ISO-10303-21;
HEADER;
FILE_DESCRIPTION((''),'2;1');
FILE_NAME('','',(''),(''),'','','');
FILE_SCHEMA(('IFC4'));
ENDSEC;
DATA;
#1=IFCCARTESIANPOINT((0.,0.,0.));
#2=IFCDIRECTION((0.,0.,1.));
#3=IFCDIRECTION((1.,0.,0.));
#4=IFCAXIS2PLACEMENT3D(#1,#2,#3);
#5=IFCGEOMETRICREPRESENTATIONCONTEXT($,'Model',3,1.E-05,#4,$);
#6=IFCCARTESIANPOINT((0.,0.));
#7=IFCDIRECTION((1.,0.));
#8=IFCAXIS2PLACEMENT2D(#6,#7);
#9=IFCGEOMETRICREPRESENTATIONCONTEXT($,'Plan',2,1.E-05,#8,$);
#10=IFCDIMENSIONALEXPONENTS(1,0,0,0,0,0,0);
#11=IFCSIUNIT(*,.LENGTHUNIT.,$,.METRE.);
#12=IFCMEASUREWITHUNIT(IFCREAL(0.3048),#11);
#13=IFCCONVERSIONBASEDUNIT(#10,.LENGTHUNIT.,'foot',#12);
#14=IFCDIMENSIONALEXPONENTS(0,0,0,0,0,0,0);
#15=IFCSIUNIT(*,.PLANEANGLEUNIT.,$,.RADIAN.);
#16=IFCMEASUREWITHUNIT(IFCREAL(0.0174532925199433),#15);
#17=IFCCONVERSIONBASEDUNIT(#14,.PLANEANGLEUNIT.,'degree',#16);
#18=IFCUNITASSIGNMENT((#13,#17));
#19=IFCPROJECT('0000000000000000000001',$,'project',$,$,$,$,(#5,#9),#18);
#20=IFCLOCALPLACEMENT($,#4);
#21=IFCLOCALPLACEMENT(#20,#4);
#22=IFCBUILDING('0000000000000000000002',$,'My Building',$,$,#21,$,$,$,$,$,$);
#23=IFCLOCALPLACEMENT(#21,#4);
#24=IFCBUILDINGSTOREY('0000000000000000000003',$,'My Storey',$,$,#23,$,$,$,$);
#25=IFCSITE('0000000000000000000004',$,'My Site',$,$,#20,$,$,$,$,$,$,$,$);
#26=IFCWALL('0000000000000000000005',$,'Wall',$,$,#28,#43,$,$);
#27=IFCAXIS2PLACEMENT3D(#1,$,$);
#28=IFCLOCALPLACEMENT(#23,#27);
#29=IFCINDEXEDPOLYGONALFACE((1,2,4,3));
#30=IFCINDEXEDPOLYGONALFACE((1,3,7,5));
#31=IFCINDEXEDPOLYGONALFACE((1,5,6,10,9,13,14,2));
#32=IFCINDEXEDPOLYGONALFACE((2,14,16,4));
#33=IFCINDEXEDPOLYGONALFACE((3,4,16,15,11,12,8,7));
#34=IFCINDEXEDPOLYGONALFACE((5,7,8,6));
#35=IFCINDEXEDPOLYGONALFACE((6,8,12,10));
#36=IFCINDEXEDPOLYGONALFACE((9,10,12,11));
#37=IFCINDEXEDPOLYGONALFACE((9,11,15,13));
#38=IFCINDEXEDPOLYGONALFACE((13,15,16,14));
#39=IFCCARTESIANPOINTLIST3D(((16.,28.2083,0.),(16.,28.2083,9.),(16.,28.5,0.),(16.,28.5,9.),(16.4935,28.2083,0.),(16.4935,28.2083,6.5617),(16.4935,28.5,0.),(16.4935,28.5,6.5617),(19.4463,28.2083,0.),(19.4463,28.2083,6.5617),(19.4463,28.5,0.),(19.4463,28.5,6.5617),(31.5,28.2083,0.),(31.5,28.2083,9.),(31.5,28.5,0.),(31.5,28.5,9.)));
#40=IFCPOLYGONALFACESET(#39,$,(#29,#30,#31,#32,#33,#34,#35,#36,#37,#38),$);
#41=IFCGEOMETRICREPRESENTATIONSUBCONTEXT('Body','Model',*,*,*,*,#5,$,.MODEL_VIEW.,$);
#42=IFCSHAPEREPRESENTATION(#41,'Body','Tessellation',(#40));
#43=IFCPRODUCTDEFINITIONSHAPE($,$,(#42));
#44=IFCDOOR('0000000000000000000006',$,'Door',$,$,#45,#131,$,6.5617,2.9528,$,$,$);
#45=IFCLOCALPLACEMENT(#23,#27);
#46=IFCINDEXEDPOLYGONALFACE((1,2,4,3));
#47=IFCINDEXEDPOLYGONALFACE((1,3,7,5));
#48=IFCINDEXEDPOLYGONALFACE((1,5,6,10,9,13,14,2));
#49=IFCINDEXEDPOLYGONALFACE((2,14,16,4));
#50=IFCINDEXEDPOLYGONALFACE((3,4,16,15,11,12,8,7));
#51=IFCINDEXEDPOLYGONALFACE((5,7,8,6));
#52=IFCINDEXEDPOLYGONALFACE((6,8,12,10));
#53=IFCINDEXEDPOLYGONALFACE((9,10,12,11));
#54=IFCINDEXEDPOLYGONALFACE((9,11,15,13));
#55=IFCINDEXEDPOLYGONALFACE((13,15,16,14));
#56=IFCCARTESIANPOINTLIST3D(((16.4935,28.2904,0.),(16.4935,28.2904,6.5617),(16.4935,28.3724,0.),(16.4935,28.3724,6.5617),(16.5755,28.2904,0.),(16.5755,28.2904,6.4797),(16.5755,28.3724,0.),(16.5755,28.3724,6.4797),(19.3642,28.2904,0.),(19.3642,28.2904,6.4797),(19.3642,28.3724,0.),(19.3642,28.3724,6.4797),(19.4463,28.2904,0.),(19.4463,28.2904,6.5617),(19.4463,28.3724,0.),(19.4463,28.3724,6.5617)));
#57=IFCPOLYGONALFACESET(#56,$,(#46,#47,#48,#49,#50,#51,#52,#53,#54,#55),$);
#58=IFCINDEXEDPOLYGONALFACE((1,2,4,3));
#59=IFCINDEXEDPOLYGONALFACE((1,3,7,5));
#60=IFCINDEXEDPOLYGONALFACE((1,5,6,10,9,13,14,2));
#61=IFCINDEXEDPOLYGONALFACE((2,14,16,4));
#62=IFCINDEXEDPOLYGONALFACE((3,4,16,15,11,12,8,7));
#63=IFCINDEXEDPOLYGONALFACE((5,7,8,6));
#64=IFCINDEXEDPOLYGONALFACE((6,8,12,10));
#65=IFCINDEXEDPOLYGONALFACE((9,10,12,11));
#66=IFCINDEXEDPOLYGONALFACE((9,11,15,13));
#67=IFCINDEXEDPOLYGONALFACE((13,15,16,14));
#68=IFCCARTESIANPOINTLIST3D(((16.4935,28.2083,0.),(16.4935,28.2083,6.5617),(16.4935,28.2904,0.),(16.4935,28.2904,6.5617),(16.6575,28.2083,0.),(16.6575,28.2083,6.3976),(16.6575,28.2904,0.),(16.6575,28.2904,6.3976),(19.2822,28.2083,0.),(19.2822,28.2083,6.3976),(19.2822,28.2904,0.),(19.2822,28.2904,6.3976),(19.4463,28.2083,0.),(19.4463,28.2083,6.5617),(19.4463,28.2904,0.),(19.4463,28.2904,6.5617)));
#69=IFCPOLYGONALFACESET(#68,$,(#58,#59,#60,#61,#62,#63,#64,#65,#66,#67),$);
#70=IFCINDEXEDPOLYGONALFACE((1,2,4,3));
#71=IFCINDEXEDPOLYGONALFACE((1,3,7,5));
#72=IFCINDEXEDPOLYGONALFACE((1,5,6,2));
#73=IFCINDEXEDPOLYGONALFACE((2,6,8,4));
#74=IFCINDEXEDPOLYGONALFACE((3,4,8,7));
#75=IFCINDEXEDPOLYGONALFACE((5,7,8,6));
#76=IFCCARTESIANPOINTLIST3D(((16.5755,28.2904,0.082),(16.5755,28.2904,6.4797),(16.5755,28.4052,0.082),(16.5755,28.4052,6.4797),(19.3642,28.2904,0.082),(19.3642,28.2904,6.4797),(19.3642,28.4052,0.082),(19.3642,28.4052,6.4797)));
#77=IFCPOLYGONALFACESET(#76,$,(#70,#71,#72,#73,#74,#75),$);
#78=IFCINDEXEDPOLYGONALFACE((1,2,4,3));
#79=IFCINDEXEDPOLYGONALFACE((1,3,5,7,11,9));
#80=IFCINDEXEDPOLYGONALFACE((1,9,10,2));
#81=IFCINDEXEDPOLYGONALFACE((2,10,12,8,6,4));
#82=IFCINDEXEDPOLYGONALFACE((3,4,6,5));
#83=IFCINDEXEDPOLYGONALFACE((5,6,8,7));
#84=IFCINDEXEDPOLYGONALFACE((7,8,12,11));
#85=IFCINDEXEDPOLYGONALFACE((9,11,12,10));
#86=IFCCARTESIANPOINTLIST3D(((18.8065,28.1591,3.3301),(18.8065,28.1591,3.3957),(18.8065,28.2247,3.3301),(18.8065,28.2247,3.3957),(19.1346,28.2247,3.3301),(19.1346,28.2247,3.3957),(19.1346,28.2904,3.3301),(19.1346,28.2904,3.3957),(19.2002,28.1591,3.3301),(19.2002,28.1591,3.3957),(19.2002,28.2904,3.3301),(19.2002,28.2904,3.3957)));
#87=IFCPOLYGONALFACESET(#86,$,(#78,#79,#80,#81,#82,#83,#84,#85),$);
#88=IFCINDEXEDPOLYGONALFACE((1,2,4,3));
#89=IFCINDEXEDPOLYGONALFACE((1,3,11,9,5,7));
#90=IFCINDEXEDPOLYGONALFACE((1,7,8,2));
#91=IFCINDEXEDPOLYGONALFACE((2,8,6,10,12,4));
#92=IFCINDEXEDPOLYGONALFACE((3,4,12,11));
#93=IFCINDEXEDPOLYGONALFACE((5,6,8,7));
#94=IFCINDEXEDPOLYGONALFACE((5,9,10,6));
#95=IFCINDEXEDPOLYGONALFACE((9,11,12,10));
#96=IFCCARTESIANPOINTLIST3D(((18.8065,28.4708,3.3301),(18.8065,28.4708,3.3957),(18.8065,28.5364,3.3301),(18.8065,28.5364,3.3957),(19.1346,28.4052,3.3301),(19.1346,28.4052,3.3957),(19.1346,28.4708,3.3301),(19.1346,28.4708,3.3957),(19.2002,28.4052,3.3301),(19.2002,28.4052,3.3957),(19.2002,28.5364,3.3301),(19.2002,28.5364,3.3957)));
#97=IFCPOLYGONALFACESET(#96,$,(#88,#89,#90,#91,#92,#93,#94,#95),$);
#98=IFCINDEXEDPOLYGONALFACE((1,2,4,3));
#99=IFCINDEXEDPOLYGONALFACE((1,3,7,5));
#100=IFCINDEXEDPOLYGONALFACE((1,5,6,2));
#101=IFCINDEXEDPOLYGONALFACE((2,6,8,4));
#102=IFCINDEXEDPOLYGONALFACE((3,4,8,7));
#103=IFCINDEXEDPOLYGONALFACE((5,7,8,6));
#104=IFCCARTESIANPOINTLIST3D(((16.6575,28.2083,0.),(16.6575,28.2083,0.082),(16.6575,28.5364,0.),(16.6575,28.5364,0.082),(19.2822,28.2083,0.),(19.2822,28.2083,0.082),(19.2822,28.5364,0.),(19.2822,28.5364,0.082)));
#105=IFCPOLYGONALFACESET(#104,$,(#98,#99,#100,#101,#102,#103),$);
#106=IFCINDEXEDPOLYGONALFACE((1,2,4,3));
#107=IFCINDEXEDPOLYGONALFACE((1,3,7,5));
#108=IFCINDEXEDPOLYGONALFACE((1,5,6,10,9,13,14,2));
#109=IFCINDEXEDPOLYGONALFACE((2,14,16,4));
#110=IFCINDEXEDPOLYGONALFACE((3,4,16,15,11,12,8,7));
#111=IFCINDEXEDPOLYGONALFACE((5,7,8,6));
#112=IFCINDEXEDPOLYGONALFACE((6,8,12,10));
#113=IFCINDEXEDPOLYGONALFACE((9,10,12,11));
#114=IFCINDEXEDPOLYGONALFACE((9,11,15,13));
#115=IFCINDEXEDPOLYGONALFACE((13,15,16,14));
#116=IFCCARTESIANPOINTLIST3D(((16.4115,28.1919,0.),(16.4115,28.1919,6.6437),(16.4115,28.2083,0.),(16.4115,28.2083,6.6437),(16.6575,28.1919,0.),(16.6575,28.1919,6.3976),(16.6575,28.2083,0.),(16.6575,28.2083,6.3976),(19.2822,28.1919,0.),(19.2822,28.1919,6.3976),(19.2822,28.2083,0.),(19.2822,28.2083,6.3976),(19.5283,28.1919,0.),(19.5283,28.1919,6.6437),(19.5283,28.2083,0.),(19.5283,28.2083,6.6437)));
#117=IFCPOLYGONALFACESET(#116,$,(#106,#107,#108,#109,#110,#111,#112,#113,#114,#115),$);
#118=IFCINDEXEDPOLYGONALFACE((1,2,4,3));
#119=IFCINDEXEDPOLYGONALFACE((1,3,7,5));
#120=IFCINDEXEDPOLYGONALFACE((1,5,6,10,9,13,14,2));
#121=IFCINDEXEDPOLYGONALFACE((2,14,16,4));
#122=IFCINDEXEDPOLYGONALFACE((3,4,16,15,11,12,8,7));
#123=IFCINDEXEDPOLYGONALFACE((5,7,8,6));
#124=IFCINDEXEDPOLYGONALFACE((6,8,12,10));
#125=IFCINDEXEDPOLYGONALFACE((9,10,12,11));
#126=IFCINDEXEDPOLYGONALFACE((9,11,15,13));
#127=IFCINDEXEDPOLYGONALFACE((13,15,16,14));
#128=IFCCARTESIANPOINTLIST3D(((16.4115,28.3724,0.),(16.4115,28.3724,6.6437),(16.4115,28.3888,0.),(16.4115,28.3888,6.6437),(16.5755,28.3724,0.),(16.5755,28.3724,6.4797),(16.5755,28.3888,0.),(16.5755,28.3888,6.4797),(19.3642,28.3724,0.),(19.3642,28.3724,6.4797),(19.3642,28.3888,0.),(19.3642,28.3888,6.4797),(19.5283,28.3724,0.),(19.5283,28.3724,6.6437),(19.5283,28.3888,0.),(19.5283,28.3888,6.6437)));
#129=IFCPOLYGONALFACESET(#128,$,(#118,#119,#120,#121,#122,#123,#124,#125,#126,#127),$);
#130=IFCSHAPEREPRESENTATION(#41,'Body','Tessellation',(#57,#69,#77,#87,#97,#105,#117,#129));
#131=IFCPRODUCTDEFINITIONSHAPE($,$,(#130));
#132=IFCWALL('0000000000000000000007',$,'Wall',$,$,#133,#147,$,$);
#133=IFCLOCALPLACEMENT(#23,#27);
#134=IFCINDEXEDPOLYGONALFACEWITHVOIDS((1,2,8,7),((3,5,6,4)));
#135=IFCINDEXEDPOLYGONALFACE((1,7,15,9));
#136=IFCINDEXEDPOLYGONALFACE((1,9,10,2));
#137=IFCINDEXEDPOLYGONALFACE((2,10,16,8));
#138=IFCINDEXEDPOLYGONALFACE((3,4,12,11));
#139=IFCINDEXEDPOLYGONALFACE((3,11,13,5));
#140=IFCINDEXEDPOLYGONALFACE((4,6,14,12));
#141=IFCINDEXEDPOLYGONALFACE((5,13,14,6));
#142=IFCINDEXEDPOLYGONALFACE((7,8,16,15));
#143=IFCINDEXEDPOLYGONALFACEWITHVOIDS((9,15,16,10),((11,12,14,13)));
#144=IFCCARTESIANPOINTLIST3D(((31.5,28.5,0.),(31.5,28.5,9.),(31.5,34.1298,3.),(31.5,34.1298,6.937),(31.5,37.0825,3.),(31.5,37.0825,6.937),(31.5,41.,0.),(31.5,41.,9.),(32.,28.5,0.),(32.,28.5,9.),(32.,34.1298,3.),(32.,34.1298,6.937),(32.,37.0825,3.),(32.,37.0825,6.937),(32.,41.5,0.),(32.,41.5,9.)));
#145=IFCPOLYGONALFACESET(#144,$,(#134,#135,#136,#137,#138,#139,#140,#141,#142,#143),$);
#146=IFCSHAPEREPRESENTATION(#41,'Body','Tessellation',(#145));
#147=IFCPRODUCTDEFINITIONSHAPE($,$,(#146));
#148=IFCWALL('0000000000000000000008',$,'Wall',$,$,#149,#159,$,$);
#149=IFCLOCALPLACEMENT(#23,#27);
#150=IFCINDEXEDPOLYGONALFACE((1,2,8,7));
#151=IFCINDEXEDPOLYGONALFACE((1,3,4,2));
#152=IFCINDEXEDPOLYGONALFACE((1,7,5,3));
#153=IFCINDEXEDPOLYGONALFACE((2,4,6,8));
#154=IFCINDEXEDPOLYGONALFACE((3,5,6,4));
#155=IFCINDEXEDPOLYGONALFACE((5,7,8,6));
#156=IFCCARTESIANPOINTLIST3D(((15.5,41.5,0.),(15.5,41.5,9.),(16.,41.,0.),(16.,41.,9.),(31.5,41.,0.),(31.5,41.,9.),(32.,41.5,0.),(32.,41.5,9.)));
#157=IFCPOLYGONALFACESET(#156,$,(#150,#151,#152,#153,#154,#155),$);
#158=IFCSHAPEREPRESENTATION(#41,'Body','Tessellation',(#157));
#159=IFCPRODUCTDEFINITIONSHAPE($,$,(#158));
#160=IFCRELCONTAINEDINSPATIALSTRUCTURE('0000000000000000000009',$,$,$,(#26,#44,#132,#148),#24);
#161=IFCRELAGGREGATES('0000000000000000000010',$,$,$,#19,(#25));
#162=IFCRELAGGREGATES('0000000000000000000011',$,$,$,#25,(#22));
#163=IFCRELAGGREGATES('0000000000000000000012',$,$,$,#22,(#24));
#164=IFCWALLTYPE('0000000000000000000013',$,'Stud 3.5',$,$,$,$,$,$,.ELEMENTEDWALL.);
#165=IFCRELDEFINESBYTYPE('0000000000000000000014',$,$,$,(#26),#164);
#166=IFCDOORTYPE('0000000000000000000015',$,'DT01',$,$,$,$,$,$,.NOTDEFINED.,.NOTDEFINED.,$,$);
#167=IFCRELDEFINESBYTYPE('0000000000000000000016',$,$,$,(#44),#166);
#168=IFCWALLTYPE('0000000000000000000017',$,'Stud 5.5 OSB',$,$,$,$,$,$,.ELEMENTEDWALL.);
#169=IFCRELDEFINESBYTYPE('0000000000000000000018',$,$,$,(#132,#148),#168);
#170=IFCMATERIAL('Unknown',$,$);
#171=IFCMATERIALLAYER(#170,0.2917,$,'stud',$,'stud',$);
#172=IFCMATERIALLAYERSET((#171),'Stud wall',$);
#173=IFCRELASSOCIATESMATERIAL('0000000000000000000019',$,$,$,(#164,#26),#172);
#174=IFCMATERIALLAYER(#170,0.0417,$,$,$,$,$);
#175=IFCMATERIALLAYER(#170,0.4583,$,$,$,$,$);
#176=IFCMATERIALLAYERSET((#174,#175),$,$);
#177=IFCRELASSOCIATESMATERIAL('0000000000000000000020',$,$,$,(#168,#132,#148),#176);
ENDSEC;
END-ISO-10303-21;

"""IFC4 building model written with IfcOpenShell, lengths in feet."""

from ifc_helpers import new_model, entity, si_unit, converted_unit, frame, origin_with_axes, origin_2d_with_axis, place, context, subcontext, project, spatial, line, indexed_curve, outline, extrude, clip, halfspace, shape, source, transform, mapped, material, layer, layer_set, layer_usage, type_object, type_shapes, element, fill, save


model = new_model("IFC4")

# Units and contexts
model_context = context("Model", 3, precision=1e-05, world=origin_with_axes())
plan_context = context("Plan", 2, precision=1e-05, world=origin_2d_with_axis())
body_context_1 = subcontext(model_context, "Body", "Model", "MODEL_VIEW")
body_context_2 = subcontext(plan_context, "Body", "Plan", "PLAN_VIEW")
ifc_project = project(units=[converted_unit("LENGTHUNIT", "foot", entity("IfcReal", 0.3048), si_unit("LENGTHUNIT", "METRE"), dimensions=[1, 0, 0, 0, 0, 0, 0]), converted_unit("PLANEANGLEUNIT", "degree", entity("IfcReal", 0.0174532925199433), si_unit("PLANEANGLEUNIT", "RADIAN"), dimensions=[0, 0, 0, 0, 0, 0, 0])], contexts=[model_context, plan_context])

# Site, building, storey
site_placement = place(None, origin_with_axes())
site = spatial("IfcSite", under=ifc_project, at=site_placement, Name="My Site")
building_placement = place(site_placement, origin_with_axes())
building = spatial("IfcBuilding", under=site, at=building_placement, Name="My Building")
storey_placement = place(building_placement, origin_with_axes())
storey = spatial("IfcBuildingStorey", under=building, at=storey_placement, Name="My Storey")

# Wall, opening, door
ifc_material = material(Name="Unknown")
ifc_layer_1 = layer(ifc_material, 0.2917, Name="stud", Category="stud")
ifc_layer_set_1 = layer_set([ifc_layer_1], Name="Stud wall")
ifc_layer_usage_1 = layer_usage(ifc_layer_set_1, "AXIS2", "POSITIVE", 0.0)
wall_type_1 = type_object("IfcWallType", Name="Stud 3.5", PredefinedType="ELEMENTEDWALL", material=ifc_layer_set_1)
wall_1_placement = place(storey_placement, frame((31.5, 28.5, 0.0), z_axis=(0.0, 0.0, 1.0), x_axis=(-1.0, 0.000001, 0.0)))
wall_1 = element("IfcWall", 1, at=wall_1_placement, inside=storey, type_object=wall_type_1, material=ifc_layer_usage_1, Name="Wall", context=body_context_1, shape_type="SweptSolid", body=[
    extrude(outline(indexed_curve([(0.0, 0.0), (0.0, 0.2917), (15.5, 0.2917), (15.5, 0.0), (0.0, 0.0)], self_intersect=False)), origin_with_axes(), (0.0, 0.0, 1.0), 9.0),
])
shared_shape_1 = source(origin_with_axes(), body_context_1, "Body", "SweptSolid", [
    extrude(outline(indexed_curve([(0.0, 0.0), (2.9528, 0.0), (2.9528, 6.5617), (0.0, 6.5617)], segments=[line(1, 2, 3, 4, 1)])), frame((0.0, -1.9685, 0.0), z_axis=(0.0, -1.0, 0.0), x_axis=(1.0, 0.0, 0.0)), (0.0, 0.0, -1.0), 3.937),
])
opening_1_placement = place(wall_1_placement, frame((15.0065, 0.2917, 0.0), z_axis=(0.0, 0.0, 1.0), x_axis=(-1.0, 0.0, 0.0)))
opening_1 = element("IfcOpeningElement", 2, at=opening_1_placement, cuts=wall_1, PredefinedType="OPENING", context=body_context_1, shape_type="MappedRepresentation", body=[
    mapped(shared_shape_1, transform((0.0, 0.0, 0.0), x_axis=(1.0, 0.0, 0.0), y_axis=(0.0, 1.0, 0.0), z_axis=(0.0, 0.0, 1.0), scale=1.0)),
])
door_type = type_object("IfcDoorType", Name="DT01", OperationType="NOTDEFINED", PredefinedType="NOTDEFINED")
shared_shape_2 = source(origin_with_axes(), body_context_1, "Body", "SweptSolid", [
    extrude(outline(indexed_curve([(0.0, 0.0), (0.0, 6.5617), (2.9528, 6.5617), (2.9528, 0.0), (2.8707, 0.0), (2.8707, 6.4797), (0.082, 6.4797), (0.082, 0.0)], segments=[line(1, 2, 3, 4, 5, 6, 7, 8, 1)])), frame((0.0, 0.082, 0.0), z_axis=(0.0, -1.0, 0.0), x_axis=(1.0, 0.0, 0.0)), (0.0, 0.0, -1.0), 0.082),
    extrude(outline(indexed_curve([(0.0, 0.0), (0.0, 6.5617), (2.9528, 6.5617), (2.9528, 0.0), (2.7887, 0.0), (2.7887, 6.3976), (0.164, 6.3976), (0.164, 0.0)], segments=[line(1, 2, 3, 4, 5, 6, 7, 8, 1)])), frame((0.0, 0.0, 0.0), z_axis=(0.0, -1.0, 0.0), x_axis=(1.0, 0.0, 0.0)), (0.0, 0.0, -1.0), 0.082),
    extrude(outline(indexed_curve([(0.0, 0.0), (2.7887, 0.0), (2.7887, 0.1148), (0.0, 0.1148)], segments=[line(1, 2, 3, 4, 1)])), frame((0.082, 0.082, 0.082), z_axis=(0.0, 0.0, 1.0), x_axis=(1.0, 0.0, 0.0)), (0.0, 0.0, 1.0), 6.3976),
    extrude(outline(indexed_curve([(0.0, 0.0), (0.0, -0.1312), (-0.3937, -0.1312), (-0.3937, -0.0656), (-0.0656, -0.0656), (-0.0656, 0.0)], segments=[line(1, 2, 3, 4, 5, 6, 1)])), frame((2.7067, 0.082, 3.3301), z_axis=(0.0, 0.0, 1.0), x_axis=(1.0, 0.0, 0.0)), (0.0, 0.0, 1.0), 0.0656),
    extrude(outline(indexed_curve([(0.0, 0.0), (0.0, 0.1312), (-0.3937, 0.1312), (-0.3937, 0.0656), (-0.0656, 0.0656), (-0.0656, 0.0)], segments=[line(1, 2, 3, 4, 5, 6, 1)])), frame((2.7067, 0.1969, 3.3301), z_axis=(0.0, 0.0, 1.0), x_axis=(1.0, 0.0, 0.0)), (0.0, 0.0, 1.0), 0.0656),
    extrude(outline(indexed_curve([(0.0, 0.0), (2.6247, 0.0), (2.6247, 0.3281), (0.0, 0.3281)], segments=[line(1, 2, 3, 4, 1)])), frame((0.164, 0.0, 0.0), z_axis=(0.0, 0.0, 1.0), x_axis=(1.0, 0.0, 0.0)), (0.0, 0.0, 1.0), 0.082),
    extrude(outline(indexed_curve([(0.0, 0.0), (0.0, 6.6437), (3.1168, 6.6437), (3.1168, 0.0), (2.8707, 0.0), (2.8707, 6.3976), (0.2461, 6.3976), (0.2461, 0.0)], segments=[line(1, 2, 3, 4, 5, 6, 7, 8, 1)])), frame((-0.082, -0.0164, 0.0), z_axis=(0.0, -1.0, 0.0), x_axis=(1.0, 0.0, 0.0)), (0.0, 0.0, -1.0), 0.0164),
    extrude(outline(indexed_curve([(0.0, 0.0), (0.0, 6.6437), (3.1168, 6.6437), (3.1168, 0.0), (2.9528, 0.0), (2.9528, 6.4797), (0.164, 6.4797), (0.164, 0.0)], segments=[line(1, 2, 3, 4, 5, 6, 7, 8, 1)])), frame((-0.082, 0.164, 0.0), z_axis=(0.0, -1.0, 0.0), x_axis=(1.0, 0.0, 0.0)), (0.0, 0.0, -1.0), 0.0164),
])
shared_shape_3 = source(origin_with_axes(), body_context_2, "Body", "Curve2D", [
    entity("IfcIndexedPolyCurve", entity("IfcCartesianPointList2D", [[0.0, 0.0], [0.0, 0.164], [0.082, 0.164], [0.082, 0.082], [0.164, 0.082], [0.164, 0.0]]), [entity("IfcLineIndex", [1, 2, 3, 4, 5, 6, 1])]),
    entity("IfcIndexedPolyCurve", entity("IfcCartesianPointList2D", [[2.9528, 0.0], [2.9528, 0.164], [2.8707, 0.164], [2.8707, 0.082], [2.7887, 0.082], [2.7887, 0.0]]), [entity("IfcLineIndex", [1, 2, 3, 4, 5, 6, 1])]),
    entity("IfcTrimmedCurve", entity("IfcEllipse", entity("IfcAxis2Placement2D", entity("IfcCartesianPoint", [0.1969, 0.164]), entity("IfcDirection", [1.0, 0.0])), 2.6739, 2.7887), [entity("IfcCartesianPoint", [2.8707, 0.164])], [entity("IfcCartesianPoint", [0.1969, 2.9528])], True, "CARTESIAN"),
    entity("IfcIndexedPolyCurve", entity("IfcCartesianPointList2D", [[0.082, 0.164], [0.1969, 0.164], [0.1969, 2.9528], [0.082, 2.9528]]), [entity("IfcLineIndex", [1, 2, 3, 4, 1])]),
])
type_shapes(door_type, [shared_shape_2, shared_shape_3])
door_1_placement = place(opening_1_placement, frame((0.0, 0.0, 0.0), z_axis=(0.0, 0.0, 1.0), x_axis=(1.0, 0.0, 0.0)))
door_1 = element("IfcDoor", 3, at=door_1_placement, inside=storey, type_object=door_type, Name="Door", OverallHeight=6.5617, OverallWidth=2.9528, shapes=[
    shape(body_context_1, "Body", "MappedRepresentation", [mapped(shared_shape_2, transform((0.0, 0.0, 0.0), x_axis=(1.0, 0.0, 0.0), y_axis=(0.0, 1.0, 0.0), z_axis=(0.0, 0.0, 1.0), scale=1.0))]),
    shape(body_context_2, "Body", "MappedRepresentation", [mapped(shared_shape_3, transform((0.0, 0.0, 0.0), x_axis=(1.0, 0.0, 0.0), y_axis=(0.0, 1.0, 0.0), z_axis=(0.0, 0.0, 1.0), scale=1.0))]),
])
fill(opening_1, door_1)

# Wall, opening
ifc_layer_2 = layer(ifc_material, 0.0417)
ifc_layer_3 = layer(ifc_material, 0.4583)
ifc_layer_set_2 = layer_set([ifc_layer_2, ifc_layer_3])
ifc_layer_usage_2 = layer_usage(ifc_layer_set_2, "AXIS2", "POSITIVE", 0.0)
wall_type_2 = type_object("IfcWallType", Name="Stud 5.5 OSB", PredefinedType="ELEMENTEDWALL", material=ifc_layer_set_2)
wall_2_placement = place(storey_placement, frame((32.0, 28.5, 0.0), z_axis=(0.0, 0.0, 1.0), x_axis=(0.0, 1.0, 0.0)))
wall_2 = element("IfcWall", 4, at=wall_2_placement, inside=storey, type_object=wall_type_2, material=ifc_layer_usage_2, Name="Wall", context=body_context_1, shape_type="Clipping", body=[
    clip(extrude(outline(indexed_curve([(0.0, 0.0), (0.0, 0.5), (13.0, 0.5), (13.0, 0.0), (0.0, 0.0)], self_intersect=False)), origin_with_axes(), (0.0, 0.0, 1.0), 9.0), halfspace(frame((13.0, 0.0, 0.0), z_axis=(0.707106, 0.707107, 0.0), x_axis=(0.707107, -0.707107, 0.0)), False)),
])
shared_shape_4 = source(origin_with_axes(), body_context_1, "Body", "SweptSolid", [
    extrude(outline(indexed_curve([(0.0, 0.0), (2.9528, 0.0), (2.9528, 3.937), (0.0, 3.937)], segments=[line(1, 2, 3, 4, 1)])), frame((0.0, -1.9685, 0.0), z_axis=(0.0, -1.0, 0.0), x_axis=(1.0, 0.0, 0.0)), (0.0, 0.0, -1.0), 3.937),
])
opening_2_placement = place(wall_2_placement, frame((5.6298, 0.0, 3.0), z_axis=(0.0, 0.0, 1.0), x_axis=(1.0, 0.0, 0.0)))
element("IfcOpeningElement", 5, at=opening_2_placement, cuts=wall_2, PredefinedType="OPENING", context=body_context_1, shape_type="MappedRepresentation", body=[
    mapped(shared_shape_4, transform((0.0, 0.0, 0.0), x_axis=(1.0, 0.0, 0.0), y_axis=(0.0, 1.0, 0.0), z_axis=(0.0, 0.0, 1.0), scale=1.0)),
])

# Wall
ifc_layer_usage_3 = layer_usage(ifc_layer_set_2, "AXIS2", "POSITIVE", 0.0)
wall_3_placement = place(storey_placement, frame((32.0, 41.5, 0.0), z_axis=(0.0, 0.0, 1.0), x_axis=(-1.0, 0.0, 0.0)))
element("IfcWall", 6, at=wall_3_placement, inside=storey, type_object=wall_type_2, material=ifc_layer_usage_3, Name="Wall", context=body_context_1, shape_type="Clipping", body=[
    clip(clip(extrude(outline(indexed_curve([(0.0, 0.0), (0.0, 0.5), (16.5, 0.5), (16.5, 0.0), (0.0, 0.0)], self_intersect=False)), origin_with_axes(), (0.0, 0.0, 1.0), 9.0), halfspace(frame((0.0, 0.0, 0.0), z_axis=(-0.707107, 0.707106, 0.0), x_axis=(0.707106, 0.707107, 0.0)), False)), halfspace(frame((16.5, 0.0, 0.0), z_axis=(0.707106, 0.707107, 0.0), x_axis=(0.707107, -0.707106, 0.0)), False)),
])

save(model, "model.ifc")
